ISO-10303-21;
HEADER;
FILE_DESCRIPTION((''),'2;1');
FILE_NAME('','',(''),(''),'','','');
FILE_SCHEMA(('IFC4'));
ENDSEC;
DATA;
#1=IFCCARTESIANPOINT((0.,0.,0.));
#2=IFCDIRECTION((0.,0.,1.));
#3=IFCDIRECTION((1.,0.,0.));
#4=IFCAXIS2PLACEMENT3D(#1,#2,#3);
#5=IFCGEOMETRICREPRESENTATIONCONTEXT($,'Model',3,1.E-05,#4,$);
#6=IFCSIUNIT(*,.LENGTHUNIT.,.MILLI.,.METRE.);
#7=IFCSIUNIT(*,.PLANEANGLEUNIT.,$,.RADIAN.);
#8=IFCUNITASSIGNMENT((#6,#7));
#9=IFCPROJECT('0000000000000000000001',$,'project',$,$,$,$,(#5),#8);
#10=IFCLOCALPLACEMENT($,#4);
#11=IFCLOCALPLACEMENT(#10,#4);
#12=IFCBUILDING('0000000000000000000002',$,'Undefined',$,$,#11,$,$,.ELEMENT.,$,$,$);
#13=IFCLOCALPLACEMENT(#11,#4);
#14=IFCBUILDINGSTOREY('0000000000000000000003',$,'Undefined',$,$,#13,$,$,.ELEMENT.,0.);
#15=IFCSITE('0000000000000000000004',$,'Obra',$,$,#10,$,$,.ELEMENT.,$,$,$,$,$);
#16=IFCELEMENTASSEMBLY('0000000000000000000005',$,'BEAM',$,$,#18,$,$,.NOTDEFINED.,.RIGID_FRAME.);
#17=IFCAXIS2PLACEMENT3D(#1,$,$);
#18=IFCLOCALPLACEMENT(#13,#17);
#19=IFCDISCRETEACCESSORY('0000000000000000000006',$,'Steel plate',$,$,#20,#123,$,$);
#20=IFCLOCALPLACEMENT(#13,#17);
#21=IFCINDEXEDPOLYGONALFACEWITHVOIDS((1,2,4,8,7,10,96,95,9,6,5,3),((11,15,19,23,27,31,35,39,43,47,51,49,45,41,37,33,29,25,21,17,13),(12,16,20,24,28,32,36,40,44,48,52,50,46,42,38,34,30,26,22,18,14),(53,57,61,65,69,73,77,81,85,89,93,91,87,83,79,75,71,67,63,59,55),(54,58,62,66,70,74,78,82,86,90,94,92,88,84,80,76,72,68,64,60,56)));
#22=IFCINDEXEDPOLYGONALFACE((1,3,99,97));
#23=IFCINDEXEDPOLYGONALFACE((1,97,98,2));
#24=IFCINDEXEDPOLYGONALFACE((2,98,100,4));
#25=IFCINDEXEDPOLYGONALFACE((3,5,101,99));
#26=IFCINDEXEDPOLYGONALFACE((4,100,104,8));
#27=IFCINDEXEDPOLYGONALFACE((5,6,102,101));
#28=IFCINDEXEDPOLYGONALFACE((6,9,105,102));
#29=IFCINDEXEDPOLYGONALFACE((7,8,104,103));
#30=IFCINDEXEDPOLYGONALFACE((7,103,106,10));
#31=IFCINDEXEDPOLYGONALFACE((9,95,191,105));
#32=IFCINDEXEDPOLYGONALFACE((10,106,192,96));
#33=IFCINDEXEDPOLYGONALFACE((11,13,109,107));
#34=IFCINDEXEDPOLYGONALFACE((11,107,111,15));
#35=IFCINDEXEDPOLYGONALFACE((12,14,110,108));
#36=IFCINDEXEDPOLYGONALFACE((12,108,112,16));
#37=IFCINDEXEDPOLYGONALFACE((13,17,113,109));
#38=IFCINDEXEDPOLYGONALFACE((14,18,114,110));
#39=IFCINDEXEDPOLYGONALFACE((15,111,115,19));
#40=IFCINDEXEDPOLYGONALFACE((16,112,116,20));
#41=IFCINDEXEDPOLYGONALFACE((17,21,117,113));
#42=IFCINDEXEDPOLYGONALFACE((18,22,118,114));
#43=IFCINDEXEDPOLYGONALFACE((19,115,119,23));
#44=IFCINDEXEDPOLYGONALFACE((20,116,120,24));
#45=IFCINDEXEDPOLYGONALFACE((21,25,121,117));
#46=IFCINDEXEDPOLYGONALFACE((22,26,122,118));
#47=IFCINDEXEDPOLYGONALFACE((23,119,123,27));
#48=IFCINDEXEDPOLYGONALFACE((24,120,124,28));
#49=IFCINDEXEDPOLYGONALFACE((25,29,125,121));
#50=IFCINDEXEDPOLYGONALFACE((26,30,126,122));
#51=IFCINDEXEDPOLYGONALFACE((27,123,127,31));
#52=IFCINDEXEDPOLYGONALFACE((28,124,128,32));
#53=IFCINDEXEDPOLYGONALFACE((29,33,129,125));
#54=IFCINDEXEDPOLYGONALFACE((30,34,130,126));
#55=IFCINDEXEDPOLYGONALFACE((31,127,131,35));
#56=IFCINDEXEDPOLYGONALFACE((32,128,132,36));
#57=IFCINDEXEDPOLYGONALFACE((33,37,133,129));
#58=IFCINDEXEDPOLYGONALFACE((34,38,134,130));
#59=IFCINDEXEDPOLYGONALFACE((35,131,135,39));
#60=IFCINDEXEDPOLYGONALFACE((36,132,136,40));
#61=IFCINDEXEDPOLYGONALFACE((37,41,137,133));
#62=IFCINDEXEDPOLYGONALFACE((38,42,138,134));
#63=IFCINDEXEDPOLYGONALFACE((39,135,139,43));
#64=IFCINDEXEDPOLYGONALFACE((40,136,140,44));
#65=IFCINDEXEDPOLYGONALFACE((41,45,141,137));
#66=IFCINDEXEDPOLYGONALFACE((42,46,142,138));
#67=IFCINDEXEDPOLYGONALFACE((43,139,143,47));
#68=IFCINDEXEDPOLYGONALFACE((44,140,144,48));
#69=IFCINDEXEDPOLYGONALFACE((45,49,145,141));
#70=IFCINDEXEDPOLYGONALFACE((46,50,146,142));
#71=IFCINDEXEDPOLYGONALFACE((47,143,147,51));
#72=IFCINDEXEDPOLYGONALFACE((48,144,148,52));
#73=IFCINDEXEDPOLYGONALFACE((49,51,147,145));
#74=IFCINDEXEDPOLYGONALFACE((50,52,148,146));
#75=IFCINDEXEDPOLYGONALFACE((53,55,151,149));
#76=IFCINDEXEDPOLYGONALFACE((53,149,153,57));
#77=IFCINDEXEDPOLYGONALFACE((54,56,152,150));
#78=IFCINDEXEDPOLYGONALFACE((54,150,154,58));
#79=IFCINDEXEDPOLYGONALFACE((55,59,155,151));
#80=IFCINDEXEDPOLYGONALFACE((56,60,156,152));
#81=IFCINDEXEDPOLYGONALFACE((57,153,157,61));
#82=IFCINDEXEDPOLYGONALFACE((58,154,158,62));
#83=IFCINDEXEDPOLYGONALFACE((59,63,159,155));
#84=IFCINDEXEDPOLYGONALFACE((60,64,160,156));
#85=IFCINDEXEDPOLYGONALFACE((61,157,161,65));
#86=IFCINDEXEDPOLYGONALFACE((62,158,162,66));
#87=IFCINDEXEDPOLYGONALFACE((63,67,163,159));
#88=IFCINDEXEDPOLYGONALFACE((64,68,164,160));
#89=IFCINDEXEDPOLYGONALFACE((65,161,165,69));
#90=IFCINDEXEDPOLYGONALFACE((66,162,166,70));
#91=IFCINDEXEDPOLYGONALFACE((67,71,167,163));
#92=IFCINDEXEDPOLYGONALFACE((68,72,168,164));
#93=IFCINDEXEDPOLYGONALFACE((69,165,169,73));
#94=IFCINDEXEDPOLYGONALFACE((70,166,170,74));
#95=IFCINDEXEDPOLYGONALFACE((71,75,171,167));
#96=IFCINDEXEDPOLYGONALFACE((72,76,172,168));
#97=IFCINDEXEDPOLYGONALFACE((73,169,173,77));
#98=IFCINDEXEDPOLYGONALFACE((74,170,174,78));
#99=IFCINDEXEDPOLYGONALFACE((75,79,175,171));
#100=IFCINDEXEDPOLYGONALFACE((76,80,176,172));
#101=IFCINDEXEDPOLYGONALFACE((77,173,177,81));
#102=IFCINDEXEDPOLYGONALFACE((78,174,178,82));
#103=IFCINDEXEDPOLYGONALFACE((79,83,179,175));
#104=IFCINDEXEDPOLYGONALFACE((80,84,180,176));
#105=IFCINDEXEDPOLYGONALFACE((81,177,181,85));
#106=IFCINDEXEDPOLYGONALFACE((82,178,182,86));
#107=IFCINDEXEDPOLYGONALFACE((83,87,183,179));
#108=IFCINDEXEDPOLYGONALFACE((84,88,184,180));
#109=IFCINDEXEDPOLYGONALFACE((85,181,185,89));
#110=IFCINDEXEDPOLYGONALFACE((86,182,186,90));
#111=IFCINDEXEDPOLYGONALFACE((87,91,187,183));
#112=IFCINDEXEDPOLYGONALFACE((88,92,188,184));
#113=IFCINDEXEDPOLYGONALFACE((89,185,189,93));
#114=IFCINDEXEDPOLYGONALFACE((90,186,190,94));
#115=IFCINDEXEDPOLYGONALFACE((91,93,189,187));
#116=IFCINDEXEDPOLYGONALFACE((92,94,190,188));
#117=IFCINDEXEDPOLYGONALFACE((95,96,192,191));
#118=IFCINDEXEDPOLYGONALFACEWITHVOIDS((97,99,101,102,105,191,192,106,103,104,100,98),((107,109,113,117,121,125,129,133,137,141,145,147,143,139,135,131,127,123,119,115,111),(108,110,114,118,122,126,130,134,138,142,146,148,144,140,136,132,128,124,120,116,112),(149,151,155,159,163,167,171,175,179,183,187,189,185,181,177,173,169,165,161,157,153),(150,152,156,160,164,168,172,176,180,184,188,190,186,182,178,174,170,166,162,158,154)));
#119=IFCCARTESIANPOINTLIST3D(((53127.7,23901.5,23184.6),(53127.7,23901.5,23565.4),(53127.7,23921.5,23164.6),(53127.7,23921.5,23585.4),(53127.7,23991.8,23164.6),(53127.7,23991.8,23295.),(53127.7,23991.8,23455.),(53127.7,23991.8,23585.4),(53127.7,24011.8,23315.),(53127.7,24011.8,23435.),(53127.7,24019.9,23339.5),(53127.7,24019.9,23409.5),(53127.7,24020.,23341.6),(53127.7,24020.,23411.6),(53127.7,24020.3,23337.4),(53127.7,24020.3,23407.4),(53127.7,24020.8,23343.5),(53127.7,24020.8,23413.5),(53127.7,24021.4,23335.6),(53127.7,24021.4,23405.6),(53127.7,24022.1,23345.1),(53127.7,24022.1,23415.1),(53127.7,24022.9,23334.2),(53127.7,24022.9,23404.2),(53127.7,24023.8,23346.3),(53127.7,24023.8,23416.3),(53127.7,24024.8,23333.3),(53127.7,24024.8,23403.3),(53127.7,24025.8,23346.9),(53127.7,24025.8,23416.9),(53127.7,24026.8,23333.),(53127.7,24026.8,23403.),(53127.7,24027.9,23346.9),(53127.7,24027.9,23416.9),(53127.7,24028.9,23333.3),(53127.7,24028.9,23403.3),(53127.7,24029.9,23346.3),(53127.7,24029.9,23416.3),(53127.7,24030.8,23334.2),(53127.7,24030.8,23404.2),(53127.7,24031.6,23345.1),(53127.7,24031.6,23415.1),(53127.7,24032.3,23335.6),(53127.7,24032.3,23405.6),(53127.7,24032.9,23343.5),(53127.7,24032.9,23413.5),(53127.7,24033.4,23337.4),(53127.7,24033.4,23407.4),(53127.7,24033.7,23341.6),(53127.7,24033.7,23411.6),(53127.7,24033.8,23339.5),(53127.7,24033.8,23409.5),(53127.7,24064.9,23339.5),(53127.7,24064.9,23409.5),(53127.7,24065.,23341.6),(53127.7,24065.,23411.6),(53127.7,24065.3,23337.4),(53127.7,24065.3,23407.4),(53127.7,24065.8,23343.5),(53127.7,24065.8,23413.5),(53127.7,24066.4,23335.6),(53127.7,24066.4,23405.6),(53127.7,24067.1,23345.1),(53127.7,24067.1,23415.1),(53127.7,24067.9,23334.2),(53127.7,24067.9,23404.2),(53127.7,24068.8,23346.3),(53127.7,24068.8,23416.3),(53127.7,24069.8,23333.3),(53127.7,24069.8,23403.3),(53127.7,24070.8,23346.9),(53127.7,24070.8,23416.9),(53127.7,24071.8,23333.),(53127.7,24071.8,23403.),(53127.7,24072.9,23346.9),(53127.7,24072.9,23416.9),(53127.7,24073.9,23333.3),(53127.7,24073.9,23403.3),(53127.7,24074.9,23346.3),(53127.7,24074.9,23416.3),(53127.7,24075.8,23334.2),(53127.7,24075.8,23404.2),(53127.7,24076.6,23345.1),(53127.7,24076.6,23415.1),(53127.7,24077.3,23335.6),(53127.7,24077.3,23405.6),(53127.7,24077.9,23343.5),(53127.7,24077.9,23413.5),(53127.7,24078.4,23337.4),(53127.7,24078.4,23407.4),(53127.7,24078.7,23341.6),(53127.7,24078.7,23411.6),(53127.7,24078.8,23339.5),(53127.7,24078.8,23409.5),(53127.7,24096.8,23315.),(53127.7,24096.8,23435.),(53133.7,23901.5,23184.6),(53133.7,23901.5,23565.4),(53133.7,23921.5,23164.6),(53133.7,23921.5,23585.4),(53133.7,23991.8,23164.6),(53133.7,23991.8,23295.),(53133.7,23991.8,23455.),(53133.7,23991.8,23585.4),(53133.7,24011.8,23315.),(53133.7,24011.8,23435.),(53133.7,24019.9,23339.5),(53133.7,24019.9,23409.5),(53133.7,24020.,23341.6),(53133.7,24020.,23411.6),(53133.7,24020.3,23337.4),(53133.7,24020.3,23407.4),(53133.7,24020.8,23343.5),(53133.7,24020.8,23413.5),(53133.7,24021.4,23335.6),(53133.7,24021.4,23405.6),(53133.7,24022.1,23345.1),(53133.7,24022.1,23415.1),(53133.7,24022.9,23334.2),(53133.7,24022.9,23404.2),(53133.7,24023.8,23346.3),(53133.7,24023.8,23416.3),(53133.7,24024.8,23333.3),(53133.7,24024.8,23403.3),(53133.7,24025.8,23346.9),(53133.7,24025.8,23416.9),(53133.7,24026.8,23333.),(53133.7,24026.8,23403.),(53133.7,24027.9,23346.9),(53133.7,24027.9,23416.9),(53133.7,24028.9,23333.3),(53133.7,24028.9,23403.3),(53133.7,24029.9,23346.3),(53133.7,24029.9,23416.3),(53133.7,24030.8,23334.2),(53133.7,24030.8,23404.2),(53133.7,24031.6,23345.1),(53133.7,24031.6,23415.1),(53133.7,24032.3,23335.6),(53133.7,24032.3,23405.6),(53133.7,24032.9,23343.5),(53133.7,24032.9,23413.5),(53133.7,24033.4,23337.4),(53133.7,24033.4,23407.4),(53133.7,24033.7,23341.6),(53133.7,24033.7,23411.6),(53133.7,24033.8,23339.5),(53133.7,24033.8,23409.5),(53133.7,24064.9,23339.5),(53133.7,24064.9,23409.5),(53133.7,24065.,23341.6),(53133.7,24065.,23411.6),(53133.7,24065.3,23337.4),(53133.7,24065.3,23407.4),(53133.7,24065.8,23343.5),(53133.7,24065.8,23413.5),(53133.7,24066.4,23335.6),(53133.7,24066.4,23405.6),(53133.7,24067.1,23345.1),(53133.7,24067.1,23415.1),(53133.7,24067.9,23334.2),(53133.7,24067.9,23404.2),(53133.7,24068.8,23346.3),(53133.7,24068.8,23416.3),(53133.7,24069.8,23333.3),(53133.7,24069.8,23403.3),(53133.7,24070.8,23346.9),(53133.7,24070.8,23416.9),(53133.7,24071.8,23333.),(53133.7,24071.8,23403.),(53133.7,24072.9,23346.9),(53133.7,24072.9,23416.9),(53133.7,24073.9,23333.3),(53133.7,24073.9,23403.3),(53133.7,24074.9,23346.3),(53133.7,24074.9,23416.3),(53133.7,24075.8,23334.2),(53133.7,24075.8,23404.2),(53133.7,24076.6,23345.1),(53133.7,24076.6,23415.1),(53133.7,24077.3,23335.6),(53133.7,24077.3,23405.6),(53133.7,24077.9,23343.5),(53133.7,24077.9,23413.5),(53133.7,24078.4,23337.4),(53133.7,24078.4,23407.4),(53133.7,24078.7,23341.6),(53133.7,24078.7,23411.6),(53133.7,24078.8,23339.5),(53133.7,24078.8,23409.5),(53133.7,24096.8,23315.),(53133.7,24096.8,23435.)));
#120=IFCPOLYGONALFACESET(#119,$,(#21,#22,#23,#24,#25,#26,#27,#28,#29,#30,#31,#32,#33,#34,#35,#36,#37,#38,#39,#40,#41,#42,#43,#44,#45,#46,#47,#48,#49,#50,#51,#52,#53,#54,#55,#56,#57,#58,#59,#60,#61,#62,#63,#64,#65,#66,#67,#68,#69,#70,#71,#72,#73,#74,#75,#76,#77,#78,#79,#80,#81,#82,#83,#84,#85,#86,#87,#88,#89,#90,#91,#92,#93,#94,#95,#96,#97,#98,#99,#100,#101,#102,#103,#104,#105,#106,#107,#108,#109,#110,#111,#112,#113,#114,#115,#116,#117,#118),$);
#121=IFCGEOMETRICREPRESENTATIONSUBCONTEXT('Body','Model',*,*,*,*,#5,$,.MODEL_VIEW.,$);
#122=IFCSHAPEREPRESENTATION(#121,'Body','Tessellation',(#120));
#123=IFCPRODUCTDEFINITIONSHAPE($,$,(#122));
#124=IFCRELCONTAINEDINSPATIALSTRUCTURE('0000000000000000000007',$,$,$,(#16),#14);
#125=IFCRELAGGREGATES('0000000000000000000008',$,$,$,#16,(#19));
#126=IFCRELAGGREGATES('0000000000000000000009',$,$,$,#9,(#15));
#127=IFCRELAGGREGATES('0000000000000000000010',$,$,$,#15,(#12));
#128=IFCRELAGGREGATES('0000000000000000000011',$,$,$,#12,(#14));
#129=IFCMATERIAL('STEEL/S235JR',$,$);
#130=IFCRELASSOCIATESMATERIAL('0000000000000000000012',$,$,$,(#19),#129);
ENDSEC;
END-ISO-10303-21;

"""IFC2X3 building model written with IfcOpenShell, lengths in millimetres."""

from ifc_helpers import new_model, si_unit, frame, origin_with_axes, origin_2d_with_axis, place, context, subcontext, project, spatial, polyline, circle, outline, extrude, source, transform, mapped, material, element, aggregate, save


model = new_model("IFC2X3")

# Units and contexts
model_context = context("Model", 3, precision=1e-05, world=origin_with_axes())
body_context = subcontext(model_context, "Body", "Model", "MODEL_VIEW")
ifc_project = project(units=[si_unit("LENGTHUNIT", "METRE", prefix="MILLI"), si_unit("PLANEANGLEUNIT", "RADIAN")], contexts=[model_context])

# Site, building, storey
site_placement = place(None, origin_with_axes())
site = spatial("IfcSite", under=ifc_project, at=site_placement, Name="Obra", CompositionType="ELEMENT")
building_placement = place(site_placement, origin_with_axes())
building = spatial("IfcBuilding", under=site, at=building_placement, Name="Undefined", CompositionType="ELEMENT")
storey_placement = place(building_placement, origin_with_axes())
storey = spatial("IfcBuildingStorey", under=building, at=storey_placement, Name="Undefined", CompositionType="ELEMENT", Elevation=0.0)

# Shared definitions
ifc_material_1 = material(Name="STEEL/S235JR")

# Element assembly
assembly_1_placement = place(storey_placement, origin_with_axes())
assembly_1 = element("IfcElementAssembly", 1, at=assembly_1_placement, inside=storey, Name="BEAM", AssemblyPlace="NOTDEFINED", PredefinedType="RIGID_FRAME")
shared_shape_1 = source(origin_with_axes(), body_context, "Body", "SweptSolid", [
    extrude(circle(Radius=7.0, at=origin_2d_with_axis()), frame((0.0, -8.6, 0.0), z_axis=(0.0, 1.0, 0.0), x_axis=(1.0, 0.0, 0.0)), (0.0, 0.0, 1.0), 6.2),
])

# Discrete accessory, opening
discrete_accessory_1_placement = place(assembly_1_placement, frame((53130.7, 23901.5, 23184.6), z_axis=(1.0, 0.0, 0.0), x_axis=(0.0, 0.707107, -0.707107)))
discrete_accessory_1 = element("IfcDiscreteAccessory", 2, at=discrete_accessory_1_placement, material=ifc_material_1, Name="Steel plate", context=body_context, shape_type="SweptSolid", body=[
    extrude(outline(polyline([(0.0, 0.0), (28.3, 0.0), (78.0, 49.7), (-14.2, 141.9), (-14.2, 170.2), (45.9, 230.3), (-39.0, 315.2), (-99.1, 255.1), (-127.3, 255.1), (-219.6, 347.3), (-269.3, 297.6), (-269.3, 269.3), (0.0, 0.0)])), frame((0.0, 0.0, -3.0), z_axis=(0.0, 0.0, 1.0), x_axis=(1.0, 0.0, 0.0)), (0.0, 0.0, 1.0), 6.0),
])
opening_1_placement = place(assembly_1_placement, frame((53125.2, 24001.8, 23435.0), z_axis=(0.0, 1.0, 0.0), x_axis=(0.0, 0.0, -1.0)))
element("IfcOpeningElement", 3, at=opening_1_placement, cuts=discrete_accessory_1, ObjectType="Opening", context=body_context, shape_type="MappedRepresentation", body=[
    mapped(shared_shape_1, transform((25.0, 0.0, 25.0))),
    mapped(shared_shape_1, transform((25.0, 0.0, 70.0))),
    mapped(shared_shape_1, transform((95.0, 0.0, 25.0))),
    mapped(shared_shape_1, transform((95.0, 0.0, 70.0))),
])
aggregate(assembly_1, [discrete_accessory_1])

save(model, "model.ifc")
